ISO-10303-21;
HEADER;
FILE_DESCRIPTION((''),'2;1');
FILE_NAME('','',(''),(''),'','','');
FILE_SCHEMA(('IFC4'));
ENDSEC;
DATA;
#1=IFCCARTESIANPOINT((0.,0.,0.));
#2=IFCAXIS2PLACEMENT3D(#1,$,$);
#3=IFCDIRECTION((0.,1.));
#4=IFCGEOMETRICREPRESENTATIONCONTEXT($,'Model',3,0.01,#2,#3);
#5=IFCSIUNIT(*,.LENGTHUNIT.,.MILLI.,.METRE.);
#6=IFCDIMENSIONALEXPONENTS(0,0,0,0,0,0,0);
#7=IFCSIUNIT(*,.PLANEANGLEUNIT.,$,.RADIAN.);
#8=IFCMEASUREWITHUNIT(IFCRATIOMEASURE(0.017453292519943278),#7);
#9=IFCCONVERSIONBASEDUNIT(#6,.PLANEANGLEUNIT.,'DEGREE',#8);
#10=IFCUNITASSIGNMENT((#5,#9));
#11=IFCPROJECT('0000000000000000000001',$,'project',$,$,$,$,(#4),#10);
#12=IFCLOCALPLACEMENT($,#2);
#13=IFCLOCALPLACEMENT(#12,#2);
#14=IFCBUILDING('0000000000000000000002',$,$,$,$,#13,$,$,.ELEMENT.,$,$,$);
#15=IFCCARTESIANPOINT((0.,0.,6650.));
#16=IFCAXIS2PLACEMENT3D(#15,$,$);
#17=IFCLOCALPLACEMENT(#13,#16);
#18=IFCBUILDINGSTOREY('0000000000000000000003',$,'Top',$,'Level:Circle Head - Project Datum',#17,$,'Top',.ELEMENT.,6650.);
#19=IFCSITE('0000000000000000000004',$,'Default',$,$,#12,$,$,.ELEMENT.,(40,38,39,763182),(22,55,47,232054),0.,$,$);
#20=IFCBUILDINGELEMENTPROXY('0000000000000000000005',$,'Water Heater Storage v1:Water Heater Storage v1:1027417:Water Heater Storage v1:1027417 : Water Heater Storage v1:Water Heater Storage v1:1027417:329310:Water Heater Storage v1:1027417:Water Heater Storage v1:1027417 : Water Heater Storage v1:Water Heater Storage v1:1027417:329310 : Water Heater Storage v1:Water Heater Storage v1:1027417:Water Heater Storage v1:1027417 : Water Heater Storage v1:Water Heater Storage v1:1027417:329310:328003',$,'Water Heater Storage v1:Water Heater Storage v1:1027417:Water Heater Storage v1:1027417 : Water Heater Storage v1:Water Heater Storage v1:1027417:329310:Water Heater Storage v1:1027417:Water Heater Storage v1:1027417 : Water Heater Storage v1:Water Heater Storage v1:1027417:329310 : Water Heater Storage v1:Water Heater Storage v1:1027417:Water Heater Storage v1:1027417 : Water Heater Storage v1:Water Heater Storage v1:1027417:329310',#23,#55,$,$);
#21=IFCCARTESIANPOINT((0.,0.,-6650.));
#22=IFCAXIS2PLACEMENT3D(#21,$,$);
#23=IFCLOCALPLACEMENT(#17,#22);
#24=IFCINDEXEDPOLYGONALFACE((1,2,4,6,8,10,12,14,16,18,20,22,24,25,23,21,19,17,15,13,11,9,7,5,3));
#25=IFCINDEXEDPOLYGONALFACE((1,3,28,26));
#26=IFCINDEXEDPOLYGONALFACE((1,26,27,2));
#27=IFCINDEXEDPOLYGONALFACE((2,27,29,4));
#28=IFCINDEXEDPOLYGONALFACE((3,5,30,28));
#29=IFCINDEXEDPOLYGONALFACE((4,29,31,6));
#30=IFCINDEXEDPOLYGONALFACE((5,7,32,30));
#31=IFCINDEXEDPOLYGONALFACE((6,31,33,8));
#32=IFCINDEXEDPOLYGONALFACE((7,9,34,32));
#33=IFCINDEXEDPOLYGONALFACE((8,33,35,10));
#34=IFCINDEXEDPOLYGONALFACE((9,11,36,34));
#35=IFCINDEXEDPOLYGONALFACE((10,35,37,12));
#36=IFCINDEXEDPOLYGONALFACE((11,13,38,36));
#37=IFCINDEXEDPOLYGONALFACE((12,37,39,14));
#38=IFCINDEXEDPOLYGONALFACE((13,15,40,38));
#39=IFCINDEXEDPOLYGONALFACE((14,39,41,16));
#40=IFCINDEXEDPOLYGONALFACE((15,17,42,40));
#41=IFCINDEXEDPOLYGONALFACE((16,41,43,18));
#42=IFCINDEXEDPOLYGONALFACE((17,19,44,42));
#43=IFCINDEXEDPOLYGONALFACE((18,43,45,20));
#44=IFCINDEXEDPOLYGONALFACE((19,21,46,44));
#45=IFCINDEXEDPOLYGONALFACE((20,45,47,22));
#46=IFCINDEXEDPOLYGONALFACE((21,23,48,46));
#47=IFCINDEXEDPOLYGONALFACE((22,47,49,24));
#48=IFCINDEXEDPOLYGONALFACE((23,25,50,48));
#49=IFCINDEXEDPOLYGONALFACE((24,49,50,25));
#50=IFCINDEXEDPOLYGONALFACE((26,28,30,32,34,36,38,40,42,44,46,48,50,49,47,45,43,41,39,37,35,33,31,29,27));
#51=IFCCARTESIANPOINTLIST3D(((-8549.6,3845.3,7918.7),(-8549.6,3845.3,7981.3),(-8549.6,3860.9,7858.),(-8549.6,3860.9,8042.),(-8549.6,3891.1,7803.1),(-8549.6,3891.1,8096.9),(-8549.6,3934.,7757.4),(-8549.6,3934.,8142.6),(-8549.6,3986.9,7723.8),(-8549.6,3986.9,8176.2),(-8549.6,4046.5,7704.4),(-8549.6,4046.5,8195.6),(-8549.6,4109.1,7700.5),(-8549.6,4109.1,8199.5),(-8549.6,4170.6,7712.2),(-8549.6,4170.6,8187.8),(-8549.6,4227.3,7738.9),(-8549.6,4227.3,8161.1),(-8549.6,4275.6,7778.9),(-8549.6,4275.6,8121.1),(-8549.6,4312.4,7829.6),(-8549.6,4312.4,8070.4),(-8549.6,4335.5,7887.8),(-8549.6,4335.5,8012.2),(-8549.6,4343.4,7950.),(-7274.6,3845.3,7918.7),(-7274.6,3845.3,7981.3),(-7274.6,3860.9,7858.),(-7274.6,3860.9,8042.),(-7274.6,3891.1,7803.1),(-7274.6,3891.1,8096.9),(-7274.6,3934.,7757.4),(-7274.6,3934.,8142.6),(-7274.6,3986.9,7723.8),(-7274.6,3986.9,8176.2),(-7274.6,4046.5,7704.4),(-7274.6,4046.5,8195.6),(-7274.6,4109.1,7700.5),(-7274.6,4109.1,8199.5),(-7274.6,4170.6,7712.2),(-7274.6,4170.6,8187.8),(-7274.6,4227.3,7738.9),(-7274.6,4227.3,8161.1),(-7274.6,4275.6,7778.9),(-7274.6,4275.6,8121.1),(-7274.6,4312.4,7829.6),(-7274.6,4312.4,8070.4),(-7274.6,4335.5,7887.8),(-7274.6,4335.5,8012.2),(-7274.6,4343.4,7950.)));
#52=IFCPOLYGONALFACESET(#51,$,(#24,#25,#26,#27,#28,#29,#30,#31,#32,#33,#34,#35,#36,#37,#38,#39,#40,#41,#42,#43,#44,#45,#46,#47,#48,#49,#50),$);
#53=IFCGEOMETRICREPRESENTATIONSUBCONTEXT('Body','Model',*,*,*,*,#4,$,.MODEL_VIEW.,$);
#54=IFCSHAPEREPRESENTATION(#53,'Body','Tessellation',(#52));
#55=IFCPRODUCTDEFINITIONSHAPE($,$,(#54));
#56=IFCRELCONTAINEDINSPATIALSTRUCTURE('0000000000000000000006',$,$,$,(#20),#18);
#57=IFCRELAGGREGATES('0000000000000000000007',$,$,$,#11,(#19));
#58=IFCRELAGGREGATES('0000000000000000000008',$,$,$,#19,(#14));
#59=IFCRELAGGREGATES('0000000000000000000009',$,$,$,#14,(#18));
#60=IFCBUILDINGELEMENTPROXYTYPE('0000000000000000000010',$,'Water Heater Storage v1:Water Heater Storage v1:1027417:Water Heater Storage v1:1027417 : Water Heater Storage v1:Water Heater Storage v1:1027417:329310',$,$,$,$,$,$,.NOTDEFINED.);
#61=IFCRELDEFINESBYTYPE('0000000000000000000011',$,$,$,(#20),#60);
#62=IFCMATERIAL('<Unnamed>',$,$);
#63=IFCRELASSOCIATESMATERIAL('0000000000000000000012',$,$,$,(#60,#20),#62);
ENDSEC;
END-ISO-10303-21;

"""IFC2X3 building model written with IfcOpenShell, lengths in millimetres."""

from ifc_helpers import new_model, entity, si_unit, converted_unit, direction, frame, frame_2d, origin, place, context, subcontext, project, spatial, circle, extrude, source, transform, mapped, material, type_object, type_shapes, element, save


model = new_model("IFC2X3")

# Units and contexts
model_context = context("Model", 3, precision=0.01, world=origin(), true_north=direction((0.0, 1.0)))
body_context = subcontext(model_context, "Body", "Model", "MODEL_VIEW")
ifc_project = project(units=[si_unit("LENGTHUNIT", "METRE", prefix="MILLI"), converted_unit("PLANEANGLEUNIT", "DEGREE", entity("IfcRatioMeasure", 0.017453292519943278), si_unit("PLANEANGLEUNIT", "RADIAN"), dimensions=[0, 0, 0, 0, 0, 0, 0])], contexts=[model_context])

# Site, building, storey
site_placement = place(None, origin())
site = spatial("IfcSite", under=ifc_project, at=site_placement, Name="Default", CompositionType="ELEMENT", RefLatitude=(40, 38, 39, 763182), RefLongitude=(22, 55, 47, 232054), RefElevation=0.0)
building_placement = place(site_placement, origin())
building = spatial("IfcBuilding", under=site, at=building_placement, CompositionType="ELEMENT")
storey_placement = place(building_placement, frame((0.0, 0.0, 6650.0)))
storey = spatial("IfcBuildingStorey", under=building, at=storey_placement, Name="Top", ObjectType="Level:Circle Head - Project Datum", LongName="Top", CompositionType="ELEMENT", Elevation=6650.0)

# Building element proxy
ifc_material_1 = material(Name="<Unnamed>")
building_element_proxy_type_1 = type_object("IfcBuildingElementProxyType", Name="Water Heater Storage v1:Water Heater Storage v1:1027417:Water Heater Storage v1:1027417 : Water Heater Storage v1:Water Heater Storage v1:1027417:329310", PredefinedType="NOTDEFINED", material=ifc_material_1)
shared_shape_1 = source(origin(), body_context, "Body", "SweptSolid", [
    extrude(circle(Radius=250.0, at=frame_2d((0.0, 0.0), x_axis=(1.0, 0.0))), frame((-8549.6, 4093.4, 7950.0), z_axis=(1.0, 0.0, 0.0), x_axis=(0.0, 1.0, 0.0)), (0.0, 0.0, 1.0), 1275.0),
])
type_shapes(building_element_proxy_type_1, [shared_shape_1])
proxy_1_placement = place(storey_placement, frame((0.0, 0.0, -6650.0)))
element("IfcBuildingElementProxy", 1, at=proxy_1_placement, inside=storey, type_object=building_element_proxy_type_1, material=ifc_material_1, Name="Water Heater Storage v1:Water Heater Storage v1:1027417:Water Heater Storage v1:1027417 : Water Heater Storage v1:Water Heater Storage v1:1027417:329310:Water Heater Storage v1:1027417:Water Heater Storage v1:1027417 : Water Heater Storage v1:Water Heater Storage v1:1027417:329310 : Water Heater Storage v1:Water Heater Storage v1:1027417:Water Heater Storage v1:1027417 : Water Heater Storage v1:Water Heater Storage v1:1027417:329310:328003", ObjectType="Water Heater Storage v1:Water Heater Storage v1:1027417:Water Heater Storage v1:1027417 : Water Heater Storage v1:Water Heater Storage v1:1027417:329310:Water Heater Storage v1:1027417:Water Heater Storage v1:1027417 : Water Heater Storage v1:Water Heater Storage v1:1027417:329310 : Water Heater Storage v1:Water Heater Storage v1:1027417:Water Heater Storage v1:1027417 : Water Heater Storage v1:Water Heater Storage v1:1027417:329310", context=body_context, shape_type="MappedRepresentation", body=[
    mapped(shared_shape_1, transform((0.0, 0.0, 0.0), scale=1.0)),
])

save(model, "model.ifc")
